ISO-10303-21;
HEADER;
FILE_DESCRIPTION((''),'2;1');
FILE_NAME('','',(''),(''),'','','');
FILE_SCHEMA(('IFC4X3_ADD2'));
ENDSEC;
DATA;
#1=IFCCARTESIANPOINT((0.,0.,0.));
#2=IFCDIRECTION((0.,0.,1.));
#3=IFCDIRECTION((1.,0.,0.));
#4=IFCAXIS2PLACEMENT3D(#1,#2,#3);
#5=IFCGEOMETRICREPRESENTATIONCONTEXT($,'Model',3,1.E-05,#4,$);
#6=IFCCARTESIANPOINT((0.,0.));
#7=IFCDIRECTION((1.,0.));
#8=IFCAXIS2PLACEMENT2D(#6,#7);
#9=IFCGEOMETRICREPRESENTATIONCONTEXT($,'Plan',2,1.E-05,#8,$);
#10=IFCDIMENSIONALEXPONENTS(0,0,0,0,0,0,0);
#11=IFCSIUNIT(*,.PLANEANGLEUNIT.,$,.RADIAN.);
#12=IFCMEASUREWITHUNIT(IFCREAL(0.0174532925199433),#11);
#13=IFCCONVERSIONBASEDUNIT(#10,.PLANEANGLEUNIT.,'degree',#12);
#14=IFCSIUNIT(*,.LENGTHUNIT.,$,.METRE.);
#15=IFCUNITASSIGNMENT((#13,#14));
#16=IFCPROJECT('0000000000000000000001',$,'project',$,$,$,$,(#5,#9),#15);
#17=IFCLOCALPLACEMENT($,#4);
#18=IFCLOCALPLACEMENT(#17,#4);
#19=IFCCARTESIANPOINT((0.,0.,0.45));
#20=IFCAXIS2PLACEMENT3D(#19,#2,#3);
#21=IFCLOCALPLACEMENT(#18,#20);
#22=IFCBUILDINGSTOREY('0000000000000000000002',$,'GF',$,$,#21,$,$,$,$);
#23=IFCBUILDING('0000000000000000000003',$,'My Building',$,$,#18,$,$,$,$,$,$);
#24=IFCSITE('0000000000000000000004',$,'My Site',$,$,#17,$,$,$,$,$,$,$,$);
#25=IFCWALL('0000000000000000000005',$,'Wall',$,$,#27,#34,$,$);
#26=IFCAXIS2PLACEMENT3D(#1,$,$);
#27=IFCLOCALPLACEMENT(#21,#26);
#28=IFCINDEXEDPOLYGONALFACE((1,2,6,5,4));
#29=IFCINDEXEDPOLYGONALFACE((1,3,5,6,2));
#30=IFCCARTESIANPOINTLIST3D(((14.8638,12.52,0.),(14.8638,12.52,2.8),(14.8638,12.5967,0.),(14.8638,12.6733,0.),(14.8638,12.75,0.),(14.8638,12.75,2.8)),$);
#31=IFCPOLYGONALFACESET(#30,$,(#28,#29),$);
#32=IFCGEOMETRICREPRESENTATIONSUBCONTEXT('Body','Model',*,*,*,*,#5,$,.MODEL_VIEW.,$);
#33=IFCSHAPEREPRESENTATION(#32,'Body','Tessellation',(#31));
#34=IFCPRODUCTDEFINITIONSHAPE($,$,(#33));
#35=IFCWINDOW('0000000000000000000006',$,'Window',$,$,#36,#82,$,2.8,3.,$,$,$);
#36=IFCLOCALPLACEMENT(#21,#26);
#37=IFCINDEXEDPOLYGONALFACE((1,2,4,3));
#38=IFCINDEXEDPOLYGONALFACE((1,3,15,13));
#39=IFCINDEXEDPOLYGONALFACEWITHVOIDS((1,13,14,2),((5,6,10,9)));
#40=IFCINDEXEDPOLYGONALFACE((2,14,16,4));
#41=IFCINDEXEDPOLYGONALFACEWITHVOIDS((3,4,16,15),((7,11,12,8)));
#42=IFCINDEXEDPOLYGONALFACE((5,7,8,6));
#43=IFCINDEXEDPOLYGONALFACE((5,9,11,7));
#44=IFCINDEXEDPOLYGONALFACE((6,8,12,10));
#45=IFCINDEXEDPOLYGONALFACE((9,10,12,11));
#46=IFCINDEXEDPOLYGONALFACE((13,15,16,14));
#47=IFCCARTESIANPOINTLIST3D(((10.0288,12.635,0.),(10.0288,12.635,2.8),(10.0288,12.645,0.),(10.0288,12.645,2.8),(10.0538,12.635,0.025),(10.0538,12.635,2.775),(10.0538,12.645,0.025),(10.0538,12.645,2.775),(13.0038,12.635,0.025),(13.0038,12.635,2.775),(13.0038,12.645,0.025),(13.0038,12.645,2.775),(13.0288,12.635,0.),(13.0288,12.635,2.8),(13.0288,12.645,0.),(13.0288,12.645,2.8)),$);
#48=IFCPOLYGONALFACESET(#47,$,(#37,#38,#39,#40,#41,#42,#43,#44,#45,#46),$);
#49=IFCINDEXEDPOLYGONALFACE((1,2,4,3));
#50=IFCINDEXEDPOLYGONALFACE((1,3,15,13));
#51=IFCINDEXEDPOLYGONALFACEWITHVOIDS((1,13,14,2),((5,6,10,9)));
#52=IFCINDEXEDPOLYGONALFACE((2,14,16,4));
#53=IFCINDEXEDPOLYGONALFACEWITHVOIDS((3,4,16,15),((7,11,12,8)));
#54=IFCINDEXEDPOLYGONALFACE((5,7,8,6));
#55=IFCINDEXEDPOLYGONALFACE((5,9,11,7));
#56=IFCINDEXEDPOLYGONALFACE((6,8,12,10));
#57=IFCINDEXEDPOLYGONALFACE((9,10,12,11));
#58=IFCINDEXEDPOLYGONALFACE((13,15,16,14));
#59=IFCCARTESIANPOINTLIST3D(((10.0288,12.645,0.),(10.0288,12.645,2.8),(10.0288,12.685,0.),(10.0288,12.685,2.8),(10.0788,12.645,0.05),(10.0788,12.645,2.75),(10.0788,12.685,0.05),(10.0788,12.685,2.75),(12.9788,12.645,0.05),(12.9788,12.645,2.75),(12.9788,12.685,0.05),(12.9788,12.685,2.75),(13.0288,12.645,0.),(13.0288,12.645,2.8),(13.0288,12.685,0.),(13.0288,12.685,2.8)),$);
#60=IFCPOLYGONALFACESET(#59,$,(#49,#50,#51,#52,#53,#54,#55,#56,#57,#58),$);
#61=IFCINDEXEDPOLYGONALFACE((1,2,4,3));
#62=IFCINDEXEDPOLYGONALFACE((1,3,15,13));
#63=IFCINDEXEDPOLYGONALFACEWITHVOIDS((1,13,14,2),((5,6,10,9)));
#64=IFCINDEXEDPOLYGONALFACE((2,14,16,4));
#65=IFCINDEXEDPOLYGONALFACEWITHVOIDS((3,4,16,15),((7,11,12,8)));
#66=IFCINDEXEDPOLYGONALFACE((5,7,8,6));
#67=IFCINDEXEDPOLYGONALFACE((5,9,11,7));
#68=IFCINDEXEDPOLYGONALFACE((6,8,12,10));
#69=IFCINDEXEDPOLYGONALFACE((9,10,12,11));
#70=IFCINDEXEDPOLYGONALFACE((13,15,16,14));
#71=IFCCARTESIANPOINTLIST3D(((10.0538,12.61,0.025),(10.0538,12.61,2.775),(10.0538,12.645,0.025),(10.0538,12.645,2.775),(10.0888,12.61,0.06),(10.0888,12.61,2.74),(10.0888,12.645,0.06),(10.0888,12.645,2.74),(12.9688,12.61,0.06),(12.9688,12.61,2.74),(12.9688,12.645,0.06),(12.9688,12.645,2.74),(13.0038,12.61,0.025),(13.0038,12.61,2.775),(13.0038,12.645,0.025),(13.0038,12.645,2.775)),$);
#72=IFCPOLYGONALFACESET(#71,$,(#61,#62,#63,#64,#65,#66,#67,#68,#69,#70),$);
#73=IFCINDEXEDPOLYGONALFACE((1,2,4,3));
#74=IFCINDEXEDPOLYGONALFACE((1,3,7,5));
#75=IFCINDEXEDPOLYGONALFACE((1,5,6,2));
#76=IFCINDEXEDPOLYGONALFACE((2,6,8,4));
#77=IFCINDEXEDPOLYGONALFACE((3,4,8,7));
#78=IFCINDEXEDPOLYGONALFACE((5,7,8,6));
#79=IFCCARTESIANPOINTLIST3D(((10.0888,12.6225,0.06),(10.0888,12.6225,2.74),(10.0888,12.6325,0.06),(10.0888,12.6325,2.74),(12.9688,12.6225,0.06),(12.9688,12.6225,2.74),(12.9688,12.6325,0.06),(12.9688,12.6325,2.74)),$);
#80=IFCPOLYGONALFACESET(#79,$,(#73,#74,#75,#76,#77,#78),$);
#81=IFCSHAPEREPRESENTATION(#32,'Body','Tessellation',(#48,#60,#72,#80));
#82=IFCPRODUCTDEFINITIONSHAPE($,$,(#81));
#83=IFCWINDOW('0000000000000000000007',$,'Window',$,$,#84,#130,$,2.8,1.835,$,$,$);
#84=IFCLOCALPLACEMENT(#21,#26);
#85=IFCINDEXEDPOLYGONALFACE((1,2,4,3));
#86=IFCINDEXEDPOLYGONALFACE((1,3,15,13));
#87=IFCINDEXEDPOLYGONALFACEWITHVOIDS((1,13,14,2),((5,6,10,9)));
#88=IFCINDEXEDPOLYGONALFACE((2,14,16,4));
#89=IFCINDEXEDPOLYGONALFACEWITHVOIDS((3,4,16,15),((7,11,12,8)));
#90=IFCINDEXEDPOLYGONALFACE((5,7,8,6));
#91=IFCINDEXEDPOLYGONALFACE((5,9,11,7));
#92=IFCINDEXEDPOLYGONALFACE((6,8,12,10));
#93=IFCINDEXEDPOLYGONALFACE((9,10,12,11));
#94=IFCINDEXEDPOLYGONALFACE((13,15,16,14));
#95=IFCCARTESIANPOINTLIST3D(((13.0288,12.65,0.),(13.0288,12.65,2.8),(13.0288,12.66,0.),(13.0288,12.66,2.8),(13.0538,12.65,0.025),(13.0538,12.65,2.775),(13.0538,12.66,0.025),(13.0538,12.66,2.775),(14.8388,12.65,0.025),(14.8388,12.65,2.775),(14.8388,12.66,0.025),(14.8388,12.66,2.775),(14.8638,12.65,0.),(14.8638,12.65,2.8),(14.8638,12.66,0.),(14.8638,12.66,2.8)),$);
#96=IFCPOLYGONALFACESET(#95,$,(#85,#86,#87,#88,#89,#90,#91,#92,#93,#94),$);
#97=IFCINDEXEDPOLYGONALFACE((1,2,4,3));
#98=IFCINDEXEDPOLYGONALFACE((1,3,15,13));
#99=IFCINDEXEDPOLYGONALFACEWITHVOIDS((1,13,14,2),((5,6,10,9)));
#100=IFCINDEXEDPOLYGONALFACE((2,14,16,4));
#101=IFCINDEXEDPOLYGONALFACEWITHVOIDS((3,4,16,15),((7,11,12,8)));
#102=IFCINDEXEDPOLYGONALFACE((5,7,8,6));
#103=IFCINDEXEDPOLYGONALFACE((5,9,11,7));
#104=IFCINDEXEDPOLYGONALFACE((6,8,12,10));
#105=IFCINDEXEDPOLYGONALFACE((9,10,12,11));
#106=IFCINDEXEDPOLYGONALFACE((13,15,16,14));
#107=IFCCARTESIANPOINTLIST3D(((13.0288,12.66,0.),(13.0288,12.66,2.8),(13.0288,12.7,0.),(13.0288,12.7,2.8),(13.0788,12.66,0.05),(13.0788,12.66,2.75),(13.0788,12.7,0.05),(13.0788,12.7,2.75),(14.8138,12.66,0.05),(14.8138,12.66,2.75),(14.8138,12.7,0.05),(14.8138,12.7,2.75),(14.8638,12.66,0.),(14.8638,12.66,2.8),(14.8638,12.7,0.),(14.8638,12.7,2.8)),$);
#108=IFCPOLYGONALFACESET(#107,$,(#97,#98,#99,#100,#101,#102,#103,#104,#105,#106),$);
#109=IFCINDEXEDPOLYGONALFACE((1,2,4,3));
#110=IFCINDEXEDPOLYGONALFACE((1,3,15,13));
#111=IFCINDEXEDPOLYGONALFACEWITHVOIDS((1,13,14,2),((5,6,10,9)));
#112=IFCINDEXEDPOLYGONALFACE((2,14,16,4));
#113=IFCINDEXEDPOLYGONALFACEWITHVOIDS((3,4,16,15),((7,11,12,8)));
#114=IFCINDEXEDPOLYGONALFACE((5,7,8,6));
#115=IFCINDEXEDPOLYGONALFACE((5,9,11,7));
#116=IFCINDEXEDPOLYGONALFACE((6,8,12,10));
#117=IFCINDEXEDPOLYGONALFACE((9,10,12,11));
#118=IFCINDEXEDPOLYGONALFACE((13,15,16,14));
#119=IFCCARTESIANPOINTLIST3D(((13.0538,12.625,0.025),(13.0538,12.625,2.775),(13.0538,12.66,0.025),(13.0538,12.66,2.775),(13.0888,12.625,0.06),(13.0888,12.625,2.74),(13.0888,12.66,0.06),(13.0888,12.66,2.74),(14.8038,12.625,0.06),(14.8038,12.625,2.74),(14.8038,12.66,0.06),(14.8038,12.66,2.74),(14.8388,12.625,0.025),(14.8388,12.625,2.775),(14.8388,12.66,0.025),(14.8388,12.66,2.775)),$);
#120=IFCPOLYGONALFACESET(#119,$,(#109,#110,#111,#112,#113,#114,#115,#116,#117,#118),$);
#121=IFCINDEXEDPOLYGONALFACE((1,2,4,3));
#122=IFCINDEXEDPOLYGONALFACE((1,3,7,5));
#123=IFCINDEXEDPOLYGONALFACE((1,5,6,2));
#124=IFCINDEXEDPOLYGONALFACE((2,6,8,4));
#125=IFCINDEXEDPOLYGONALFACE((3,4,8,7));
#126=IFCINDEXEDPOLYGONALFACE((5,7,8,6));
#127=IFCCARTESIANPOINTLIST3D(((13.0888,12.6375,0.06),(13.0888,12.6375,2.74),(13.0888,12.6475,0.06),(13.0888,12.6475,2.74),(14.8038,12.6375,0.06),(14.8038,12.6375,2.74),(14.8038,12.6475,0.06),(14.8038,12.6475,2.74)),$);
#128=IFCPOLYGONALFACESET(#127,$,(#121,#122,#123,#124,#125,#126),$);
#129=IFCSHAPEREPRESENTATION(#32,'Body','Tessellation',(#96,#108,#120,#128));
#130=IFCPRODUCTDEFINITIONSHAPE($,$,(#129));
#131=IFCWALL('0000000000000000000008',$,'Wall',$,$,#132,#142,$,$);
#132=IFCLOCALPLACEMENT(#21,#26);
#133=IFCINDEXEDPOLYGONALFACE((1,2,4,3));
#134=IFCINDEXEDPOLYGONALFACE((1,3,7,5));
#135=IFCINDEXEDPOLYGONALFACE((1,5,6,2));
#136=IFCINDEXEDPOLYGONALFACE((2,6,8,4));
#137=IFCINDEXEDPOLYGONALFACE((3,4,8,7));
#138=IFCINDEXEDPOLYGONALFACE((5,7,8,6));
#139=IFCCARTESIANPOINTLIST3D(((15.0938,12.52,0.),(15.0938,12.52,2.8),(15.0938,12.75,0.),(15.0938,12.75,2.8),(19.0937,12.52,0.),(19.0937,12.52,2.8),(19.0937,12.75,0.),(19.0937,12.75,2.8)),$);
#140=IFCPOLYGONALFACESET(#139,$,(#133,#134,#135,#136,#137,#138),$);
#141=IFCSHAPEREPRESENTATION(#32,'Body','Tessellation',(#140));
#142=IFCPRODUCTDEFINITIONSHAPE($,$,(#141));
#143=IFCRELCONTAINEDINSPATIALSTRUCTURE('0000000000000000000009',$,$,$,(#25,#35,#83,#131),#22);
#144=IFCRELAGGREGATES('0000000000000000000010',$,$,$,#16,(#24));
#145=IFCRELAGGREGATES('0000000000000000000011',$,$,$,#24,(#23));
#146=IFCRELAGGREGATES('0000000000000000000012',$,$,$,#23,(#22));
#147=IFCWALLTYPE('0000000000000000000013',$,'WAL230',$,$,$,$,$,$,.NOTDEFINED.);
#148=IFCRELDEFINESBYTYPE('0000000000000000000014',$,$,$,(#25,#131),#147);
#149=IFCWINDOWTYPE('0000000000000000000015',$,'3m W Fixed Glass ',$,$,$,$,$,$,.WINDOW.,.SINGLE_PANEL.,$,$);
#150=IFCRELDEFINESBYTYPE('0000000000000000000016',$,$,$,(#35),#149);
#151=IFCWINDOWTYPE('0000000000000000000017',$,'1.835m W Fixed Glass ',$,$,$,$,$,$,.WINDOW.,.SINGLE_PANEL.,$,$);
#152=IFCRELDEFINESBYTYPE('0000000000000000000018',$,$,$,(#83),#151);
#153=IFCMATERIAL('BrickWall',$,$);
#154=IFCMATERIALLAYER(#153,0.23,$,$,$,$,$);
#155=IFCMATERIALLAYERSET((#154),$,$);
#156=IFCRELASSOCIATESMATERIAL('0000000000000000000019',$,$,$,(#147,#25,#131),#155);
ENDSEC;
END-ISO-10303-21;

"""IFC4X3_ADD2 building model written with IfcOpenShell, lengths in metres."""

from ifc_helpers import new_model, entity, si_unit, converted_unit, frame, origin_with_axes, origin_2d_with_axis, place, context, subcontext, project, spatial, line, indexed_curve, outline, extrude, shape, source, transform, mapped, material, layer, layer_set, layer_usage, type_object, type_shapes, element, fill, save


model = new_model("IFC4X3_ADD2")

# Units and contexts
model_context = context("Model", 3, precision=1e-05, world=origin_with_axes())
plan_context = context("Plan", 2, precision=1e-05, world=origin_2d_with_axis())
body_context_1 = subcontext(model_context, "Body", "Model", "MODEL_VIEW")
body_context_2 = subcontext(plan_context, "Body", "Plan", "PLAN_VIEW")
ifc_project = project(units=[converted_unit("PLANEANGLEUNIT", "degree", entity("IfcReal", 0.0174532925199433), si_unit("PLANEANGLEUNIT", "RADIAN"), dimensions=[0, 0, 0, 0, 0, 0, 0]), si_unit("LENGTHUNIT", "METRE")], contexts=[model_context, plan_context])

# Site, building, storey
site_placement = place(None, origin_with_axes())
site = spatial("IfcSite", under=ifc_project, at=site_placement, Name="My Site")
building_placement = place(site_placement, origin_with_axes())
building = spatial("IfcBuilding", under=site, at=building_placement, Name="My Building")
storey_placement = place(building_placement, frame((0.0, 0.0, 0.45), z_axis=(0.0, 0.0, 1.0), x_axis=(1.0, 0.0, 0.0)))
storey = spatial("IfcBuildingStorey", under=building, at=storey_placement, Name="GF")

# Wall, openings, windows
ifc_material_1 = material(Name="BrickWall")
ifc_layer_1 = layer(ifc_material_1, 0.23)
ifc_layer_set_1 = layer_set([ifc_layer_1])
wall_type_1 = type_object("IfcWallType", Name="WAL230", PredefinedType="NOTDEFINED", material=ifc_layer_set_1)
ifc_layer_usage_1 = layer_usage(ifc_layer_set_1, "AXIS2", "POSITIVE", 0.0)
wall_1_placement = place(storey_placement, frame((14.8638, 12.75, 0.0), z_axis=(0.0, 0.0, 1.0), x_axis=(-1.0, 0.0, 0.0)))
wall_1 = element("IfcWall", 1, at=wall_1_placement, inside=storey, type_object=wall_type_1, material=ifc_layer_usage_1, Name="Wall", context=body_context_1, shape_type="SweptSolid", body=[
    extrude(outline(indexed_curve([(0.0, 0.0), (0.0, 0.23), (0.0, 0.23), (0.0, 0.0), (0.0, 0.0)], self_intersect=False)), origin_with_axes(), (0.0, 0.0, 1.0), 2.8),
])
shared_shape_1 = source(origin_with_axes(), body_context_1, "Body", "SweptSolid", [
    extrude(outline(indexed_curve([(0.0, 0.0), (3.0, 0.0), (3.0, 2.8), (0.0, 2.8)], segments=[line(1, 2, 3, 4, 1)])), frame((0.0, -0.6, 0.0), z_axis=(0.0, -1.0, 0.0), x_axis=(1.0, 0.0, 0.0)), (0.0, 0.0, -1.0), 1.2),
])
opening_1_placement = place(wall_1_placement, frame((1.835, 0.015, 0.0), z_axis=(0.0, 0.0, 1.0), x_axis=(1.0, 0.0, 0.0)))
opening_1 = element("IfcOpeningElement", 2, at=opening_1_placement, cuts=wall_1, PredefinedType="OPENING", context=body_context_1, shape_type="MappedRepresentation", body=[
    mapped(shared_shape_1, transform((0.0, 0.0, 0.0), x_axis=(1.0, 0.0, 0.0), y_axis=(0.0, 1.0, 0.0), z_axis=(0.0, 0.0, 1.0), scale=1.0)),
])
shared_shape_2 = source(origin_with_axes(), body_context_1, "Body", "SweptSolid", [
    extrude(outline(indexed_curve([(0.0, 0.0), (1.835, 0.0), (1.835, 2.8), (0.0, 2.8)], segments=[line(1, 2, 3, 4, 1)])), frame((0.0, -0.6, 0.0), z_axis=(0.0, -1.0, 0.0), x_axis=(1.0, 0.0, 0.0)), (0.0, 0.0, -1.0), 1.2),
])
opening_2_placement = place(wall_1_placement, frame((0.0, 0.0, 0.0), z_axis=(0.0, 0.0, 1.0), x_axis=(1.0, 0.0, 0.0)))
opening_2 = element("IfcOpeningElement", 3, at=opening_2_placement, cuts=wall_1, PredefinedType="OPENING", context=body_context_1, shape_type="MappedRepresentation", body=[
    mapped(shared_shape_2, transform((0.0, 0.0, 0.0), x_axis=(1.0, 0.0, 0.0), y_axis=(0.0, 1.0, 0.0), z_axis=(0.0, 0.0, 1.0), scale=1.0)),
])
window_type_1 = type_object("IfcWindowType", Name="3m W Fixed Glass ", PartitioningType="SINGLE_PANEL", PredefinedType="WINDOW")
shared_shape_3 = source(origin_with_axes(), body_context_1, "Body", "SweptSolid", [
    extrude(outline(indexed_curve([(0.0, 0.0), (3.0, 0.0), (3.0, 2.8), (0.0, 2.8)], segments=[line(1, 2, 3, 4, 1)]), holes=[indexed_curve([(0.025, 0.025), (2.975, 0.025), (2.975, 2.775), (0.025, 2.775)], segments=[line(1, 2, 3, 4, 1)])]), frame((0.0, 0.09, 0.0), z_axis=(0.0, -1.0, 0.0), x_axis=(1.0, 0.0, 0.0)), (0.0, 0.0, -1.0), 0.01),
    extrude(outline(indexed_curve([(0.0, 0.0), (3.0, 0.0), (3.0, 2.8), (0.0, 2.8)], segments=[line(1, 2, 3, 4, 1)]), holes=[indexed_curve([(0.05, 0.05), (2.95, 0.05), (2.95, 2.75), (0.05, 2.75)], segments=[line(1, 2, 3, 4, 1)])]), frame((0.0, 0.05, 0.0), z_axis=(0.0, -1.0, 0.0), x_axis=(1.0, 0.0, 0.0)), (0.0, 0.0, -1.0), 0.04),
    extrude(outline(indexed_curve([(0.0, 0.0), (2.95, 0.0), (2.95, 2.75), (0.0, 2.75)], segments=[line(1, 2, 3, 4, 1)]), holes=[indexed_curve([(0.035, 0.035), (2.915, 0.035), (2.915, 2.715), (0.035, 2.715)], segments=[line(1, 2, 3, 4, 1)])]), frame((0.025, 0.09, 0.025), z_axis=(0.0, -1.0, 0.0), x_axis=(1.0, 0.0, 0.0)), (0.0, 0.0, -1.0), 0.035),
    extrude(outline(indexed_curve([(0.035, 0.035), (2.915, 0.035), (2.915, 2.715), (0.035, 2.715)], segments=[line(1, 2, 3, 4, 1)])), frame((0.025, 0.1025, 0.025), z_axis=(0.0, -1.0, 0.0), x_axis=(1.0, 0.0, 0.0)), (0.0, 0.0, -1.0), 0.01),
])
shared_shape_4 = source(origin_with_axes(), body_context_2, "Body", "Curve2D", [
    entity("IfcIndexedPolyCurve", entity("IfcCartesianPointList2D", [[0.05, 0.05], [2.95, 0.05]])),
    entity("IfcIndexedPolyCurve", entity("IfcCartesianPointList2D", [[0.0, 0.1], [0.025, 0.1], [0.025, 0.09], [0.05, 0.09], [0.05, 0.05], [0.0, 0.05]]), [entity("IfcLineIndex", [1, 2, 3, 4, 5, 6, 1])]),
    entity("IfcIndexedPolyCurve", entity("IfcCartesianPointList2D", [[3.0, 0.1], [2.975, 0.1], [2.975, 0.09], [2.95, 0.09], [2.95, 0.05], [3.0, 0.05]]), [entity("IfcLineIndex", [1, 2, 3, 4, 5, 6, 1])]),
    entity("IfcIndexedPolyCurve", entity("IfcCartesianPointList2D", [[0.025, 0.09], [0.06, 0.09], [0.06, 0.125], [0.025, 0.125]]), [entity("IfcLineIndex", [1, 2, 3, 4, 1])]),
    entity("IfcIndexedPolyCurve", entity("IfcCartesianPointList2D", [[2.975, 0.09], [2.94, 0.09], [2.94, 0.125], [2.975, 0.125]]), [entity("IfcLineIndex", [1, 2, 3, 4, 1])]),
    entity("IfcIndexedPolyCurve", entity("IfcCartesianPointList2D", [[0.06, 0.09], [2.94, 0.09]])),
    entity("IfcIndexedPolyCurve", entity("IfcCartesianPointList2D", [[0.06, 0.125], [2.94, 0.125]])),
    entity("IfcIndexedPolyCurve", entity("IfcCartesianPointList2D", [[0.06, 0.1075], [2.94, 0.1075]])),
])
type_shapes(window_type_1, [shared_shape_3, shared_shape_4])
window_1_placement = place(opening_1_placement, frame((0.0, 0.0, 0.0), z_axis=(0.0, 0.0, 1.0), x_axis=(1.0, 0.0, 0.0)))
window_1 = element("IfcWindow", 4, at=window_1_placement, inside=storey, type_object=window_type_1, Name="Window", OverallHeight=2.8, OverallWidth=3.0, shapes=[
    shape(body_context_1, "Body", "MappedRepresentation", [mapped(shared_shape_3, transform((0.0, 0.0, 0.0), x_axis=(1.0, 0.0, 0.0), y_axis=(0.0, 1.0, 0.0), z_axis=(0.0, 0.0, 1.0), scale=1.0))]),
    shape(body_context_2, "Body", "MappedRepresentation", [mapped(shared_shape_4, transform((0.0, 0.0, 0.0), x_axis=(1.0, 0.0, 0.0), y_axis=(0.0, 1.0, 0.0), z_axis=(0.0, 0.0, 1.0), scale=1.0))]),
])
fill(opening_1, window_1)
window_type_2 = type_object("IfcWindowType", Name="1.835m W Fixed Glass ", PartitioningType="SINGLE_PANEL", PredefinedType="WINDOW")
shared_shape_5 = source(origin_with_axes(), body_context_1, "Body", "SweptSolid", [
    extrude(outline(indexed_curve([(0.0, 0.0), (1.835, 0.0), (1.835, 2.8), (0.0, 2.8)], segments=[line(1, 2, 3, 4, 1)]), holes=[indexed_curve([(0.025, 0.025), (1.81, 0.025), (1.81, 2.775), (0.025, 2.775)], segments=[line(1, 2, 3, 4, 1)])]), frame((0.0, 0.09, 0.0), z_axis=(0.0, -1.0, 0.0), x_axis=(1.0, 0.0, 0.0)), (0.0, 0.0, -1.0), 0.01),
    extrude(outline(indexed_curve([(0.0, 0.0), (1.835, 0.0), (1.835, 2.8), (0.0, 2.8)], segments=[line(1, 2, 3, 4, 1)]), holes=[indexed_curve([(0.05, 0.05), (1.785, 0.05), (1.785, 2.75), (0.05, 2.75)], segments=[line(1, 2, 3, 4, 1)])]), frame((0.0, 0.05, 0.0), z_axis=(0.0, -1.0, 0.0), x_axis=(1.0, 0.0, 0.0)), (0.0, 0.0, -1.0), 0.04),
    extrude(outline(indexed_curve([(0.0, 0.0), (1.785, 0.0), (1.785, 2.75), (0.0, 2.75)], segments=[line(1, 2, 3, 4, 1)]), holes=[indexed_curve([(0.035, 0.035), (1.75, 0.035), (1.75, 2.715), (0.035, 2.715)], segments=[line(1, 2, 3, 4, 1)])]), frame((0.025, 0.09, 0.025), z_axis=(0.0, -1.0, 0.0), x_axis=(1.0, 0.0, 0.0)), (0.0, 0.0, -1.0), 0.035),
    extrude(outline(indexed_curve([(0.035, 0.035), (1.75, 0.035), (1.75, 2.715), (0.035, 2.715)], segments=[line(1, 2, 3, 4, 1)])), frame((0.025, 0.1025, 0.025), z_axis=(0.0, -1.0, 0.0), x_axis=(1.0, 0.0, 0.0)), (0.0, 0.0, -1.0), 0.01),
])
shared_shape_6 = source(origin_with_axes(), body_context_2, "Body", "Curve2D", [
    entity("IfcIndexedPolyCurve", entity("IfcCartesianPointList2D", [[0.05, 0.05], [1.785, 0.05]])),
    entity("IfcIndexedPolyCurve", entity("IfcCartesianPointList2D", [[0.0, 0.1], [0.025, 0.1], [0.025, 0.09], [0.05, 0.09], [0.05, 0.05], [0.0, 0.05]]), [entity("IfcLineIndex", [1, 2, 3, 4, 5, 6, 1])]),
    entity("IfcIndexedPolyCurve", entity("IfcCartesianPointList2D", [[1.835, 0.1], [1.81, 0.1], [1.81, 0.09], [1.785, 0.09], [1.785, 0.05], [1.835, 0.05]]), [entity("IfcLineIndex", [1, 2, 3, 4, 5, 6, 1])]),
    entity("IfcIndexedPolyCurve", entity("IfcCartesianPointList2D", [[0.025, 0.09], [0.06, 0.09], [0.06, 0.125], [0.025, 0.125]]), [entity("IfcLineIndex", [1, 2, 3, 4, 1])]),
    entity("IfcIndexedPolyCurve", entity("IfcCartesianPointList2D", [[1.81, 0.09], [1.775, 0.09], [1.775, 0.125], [1.81, 0.125]]), [entity("IfcLineIndex", [1, 2, 3, 4, 1])]),
    entity("IfcIndexedPolyCurve", entity("IfcCartesianPointList2D", [[0.06, 0.09], [1.775, 0.09]])),
    entity("IfcIndexedPolyCurve", entity("IfcCartesianPointList2D", [[0.06, 0.125], [1.775, 0.125]])),
    entity("IfcIndexedPolyCurve", entity("IfcCartesianPointList2D", [[0.06, 0.1075], [1.775, 0.1075]])),
])
type_shapes(window_type_2, [shared_shape_5, shared_shape_6])
window_2_placement = place(opening_2_placement, frame((0.0, 0.0, 0.0), z_axis=(0.0, 0.0, 1.0), x_axis=(1.0, 0.0, 0.0)))
window_2 = element("IfcWindow", 5, at=window_2_placement, inside=storey, type_object=window_type_2, Name="Window", OverallHeight=2.8, OverallWidth=1.835, shapes=[
    shape(body_context_1, "Body", "MappedRepresentation", [mapped(shared_shape_5, transform((0.0, 0.0, 0.0), x_axis=(1.0, 0.0, 0.0), y_axis=(0.0, 1.0, 0.0), z_axis=(0.0, 0.0, 1.0), scale=1.0))]),
    shape(body_context_2, "Body", "MappedRepresentation", [mapped(shared_shape_6, transform((0.0, 0.0, 0.0), x_axis=(1.0, 0.0, 0.0), y_axis=(0.0, 1.0, 0.0), z_axis=(0.0, 0.0, 1.0), scale=1.0))]),
])
fill(opening_2, window_2)

# Wall
ifc_layer_usage_2 = layer_usage(ifc_layer_set_1, "AXIS2", "POSITIVE", 0.0)
wall_2_placement = place(storey_placement, frame((19.0937, 12.75, 0.0), z_axis=(0.0, 0.0, 1.0), x_axis=(-1.0, 0.0, 0.0)))
element("IfcWall", 6, at=wall_2_placement, inside=storey, type_object=wall_type_1, material=ifc_layer_usage_2, Name="Wall", context=body_context_1, shape_type="SweptSolid", body=[
    extrude(outline(indexed_curve([(0.0, 0.0), (0.0, 0.23), (3.9999, 0.23), (3.9999, 0.0), (0.0, 0.0)], self_intersect=False)), origin_with_axes(), (0.0, 0.0, 1.0), 2.8),
])

save(model, "model.ifc")
